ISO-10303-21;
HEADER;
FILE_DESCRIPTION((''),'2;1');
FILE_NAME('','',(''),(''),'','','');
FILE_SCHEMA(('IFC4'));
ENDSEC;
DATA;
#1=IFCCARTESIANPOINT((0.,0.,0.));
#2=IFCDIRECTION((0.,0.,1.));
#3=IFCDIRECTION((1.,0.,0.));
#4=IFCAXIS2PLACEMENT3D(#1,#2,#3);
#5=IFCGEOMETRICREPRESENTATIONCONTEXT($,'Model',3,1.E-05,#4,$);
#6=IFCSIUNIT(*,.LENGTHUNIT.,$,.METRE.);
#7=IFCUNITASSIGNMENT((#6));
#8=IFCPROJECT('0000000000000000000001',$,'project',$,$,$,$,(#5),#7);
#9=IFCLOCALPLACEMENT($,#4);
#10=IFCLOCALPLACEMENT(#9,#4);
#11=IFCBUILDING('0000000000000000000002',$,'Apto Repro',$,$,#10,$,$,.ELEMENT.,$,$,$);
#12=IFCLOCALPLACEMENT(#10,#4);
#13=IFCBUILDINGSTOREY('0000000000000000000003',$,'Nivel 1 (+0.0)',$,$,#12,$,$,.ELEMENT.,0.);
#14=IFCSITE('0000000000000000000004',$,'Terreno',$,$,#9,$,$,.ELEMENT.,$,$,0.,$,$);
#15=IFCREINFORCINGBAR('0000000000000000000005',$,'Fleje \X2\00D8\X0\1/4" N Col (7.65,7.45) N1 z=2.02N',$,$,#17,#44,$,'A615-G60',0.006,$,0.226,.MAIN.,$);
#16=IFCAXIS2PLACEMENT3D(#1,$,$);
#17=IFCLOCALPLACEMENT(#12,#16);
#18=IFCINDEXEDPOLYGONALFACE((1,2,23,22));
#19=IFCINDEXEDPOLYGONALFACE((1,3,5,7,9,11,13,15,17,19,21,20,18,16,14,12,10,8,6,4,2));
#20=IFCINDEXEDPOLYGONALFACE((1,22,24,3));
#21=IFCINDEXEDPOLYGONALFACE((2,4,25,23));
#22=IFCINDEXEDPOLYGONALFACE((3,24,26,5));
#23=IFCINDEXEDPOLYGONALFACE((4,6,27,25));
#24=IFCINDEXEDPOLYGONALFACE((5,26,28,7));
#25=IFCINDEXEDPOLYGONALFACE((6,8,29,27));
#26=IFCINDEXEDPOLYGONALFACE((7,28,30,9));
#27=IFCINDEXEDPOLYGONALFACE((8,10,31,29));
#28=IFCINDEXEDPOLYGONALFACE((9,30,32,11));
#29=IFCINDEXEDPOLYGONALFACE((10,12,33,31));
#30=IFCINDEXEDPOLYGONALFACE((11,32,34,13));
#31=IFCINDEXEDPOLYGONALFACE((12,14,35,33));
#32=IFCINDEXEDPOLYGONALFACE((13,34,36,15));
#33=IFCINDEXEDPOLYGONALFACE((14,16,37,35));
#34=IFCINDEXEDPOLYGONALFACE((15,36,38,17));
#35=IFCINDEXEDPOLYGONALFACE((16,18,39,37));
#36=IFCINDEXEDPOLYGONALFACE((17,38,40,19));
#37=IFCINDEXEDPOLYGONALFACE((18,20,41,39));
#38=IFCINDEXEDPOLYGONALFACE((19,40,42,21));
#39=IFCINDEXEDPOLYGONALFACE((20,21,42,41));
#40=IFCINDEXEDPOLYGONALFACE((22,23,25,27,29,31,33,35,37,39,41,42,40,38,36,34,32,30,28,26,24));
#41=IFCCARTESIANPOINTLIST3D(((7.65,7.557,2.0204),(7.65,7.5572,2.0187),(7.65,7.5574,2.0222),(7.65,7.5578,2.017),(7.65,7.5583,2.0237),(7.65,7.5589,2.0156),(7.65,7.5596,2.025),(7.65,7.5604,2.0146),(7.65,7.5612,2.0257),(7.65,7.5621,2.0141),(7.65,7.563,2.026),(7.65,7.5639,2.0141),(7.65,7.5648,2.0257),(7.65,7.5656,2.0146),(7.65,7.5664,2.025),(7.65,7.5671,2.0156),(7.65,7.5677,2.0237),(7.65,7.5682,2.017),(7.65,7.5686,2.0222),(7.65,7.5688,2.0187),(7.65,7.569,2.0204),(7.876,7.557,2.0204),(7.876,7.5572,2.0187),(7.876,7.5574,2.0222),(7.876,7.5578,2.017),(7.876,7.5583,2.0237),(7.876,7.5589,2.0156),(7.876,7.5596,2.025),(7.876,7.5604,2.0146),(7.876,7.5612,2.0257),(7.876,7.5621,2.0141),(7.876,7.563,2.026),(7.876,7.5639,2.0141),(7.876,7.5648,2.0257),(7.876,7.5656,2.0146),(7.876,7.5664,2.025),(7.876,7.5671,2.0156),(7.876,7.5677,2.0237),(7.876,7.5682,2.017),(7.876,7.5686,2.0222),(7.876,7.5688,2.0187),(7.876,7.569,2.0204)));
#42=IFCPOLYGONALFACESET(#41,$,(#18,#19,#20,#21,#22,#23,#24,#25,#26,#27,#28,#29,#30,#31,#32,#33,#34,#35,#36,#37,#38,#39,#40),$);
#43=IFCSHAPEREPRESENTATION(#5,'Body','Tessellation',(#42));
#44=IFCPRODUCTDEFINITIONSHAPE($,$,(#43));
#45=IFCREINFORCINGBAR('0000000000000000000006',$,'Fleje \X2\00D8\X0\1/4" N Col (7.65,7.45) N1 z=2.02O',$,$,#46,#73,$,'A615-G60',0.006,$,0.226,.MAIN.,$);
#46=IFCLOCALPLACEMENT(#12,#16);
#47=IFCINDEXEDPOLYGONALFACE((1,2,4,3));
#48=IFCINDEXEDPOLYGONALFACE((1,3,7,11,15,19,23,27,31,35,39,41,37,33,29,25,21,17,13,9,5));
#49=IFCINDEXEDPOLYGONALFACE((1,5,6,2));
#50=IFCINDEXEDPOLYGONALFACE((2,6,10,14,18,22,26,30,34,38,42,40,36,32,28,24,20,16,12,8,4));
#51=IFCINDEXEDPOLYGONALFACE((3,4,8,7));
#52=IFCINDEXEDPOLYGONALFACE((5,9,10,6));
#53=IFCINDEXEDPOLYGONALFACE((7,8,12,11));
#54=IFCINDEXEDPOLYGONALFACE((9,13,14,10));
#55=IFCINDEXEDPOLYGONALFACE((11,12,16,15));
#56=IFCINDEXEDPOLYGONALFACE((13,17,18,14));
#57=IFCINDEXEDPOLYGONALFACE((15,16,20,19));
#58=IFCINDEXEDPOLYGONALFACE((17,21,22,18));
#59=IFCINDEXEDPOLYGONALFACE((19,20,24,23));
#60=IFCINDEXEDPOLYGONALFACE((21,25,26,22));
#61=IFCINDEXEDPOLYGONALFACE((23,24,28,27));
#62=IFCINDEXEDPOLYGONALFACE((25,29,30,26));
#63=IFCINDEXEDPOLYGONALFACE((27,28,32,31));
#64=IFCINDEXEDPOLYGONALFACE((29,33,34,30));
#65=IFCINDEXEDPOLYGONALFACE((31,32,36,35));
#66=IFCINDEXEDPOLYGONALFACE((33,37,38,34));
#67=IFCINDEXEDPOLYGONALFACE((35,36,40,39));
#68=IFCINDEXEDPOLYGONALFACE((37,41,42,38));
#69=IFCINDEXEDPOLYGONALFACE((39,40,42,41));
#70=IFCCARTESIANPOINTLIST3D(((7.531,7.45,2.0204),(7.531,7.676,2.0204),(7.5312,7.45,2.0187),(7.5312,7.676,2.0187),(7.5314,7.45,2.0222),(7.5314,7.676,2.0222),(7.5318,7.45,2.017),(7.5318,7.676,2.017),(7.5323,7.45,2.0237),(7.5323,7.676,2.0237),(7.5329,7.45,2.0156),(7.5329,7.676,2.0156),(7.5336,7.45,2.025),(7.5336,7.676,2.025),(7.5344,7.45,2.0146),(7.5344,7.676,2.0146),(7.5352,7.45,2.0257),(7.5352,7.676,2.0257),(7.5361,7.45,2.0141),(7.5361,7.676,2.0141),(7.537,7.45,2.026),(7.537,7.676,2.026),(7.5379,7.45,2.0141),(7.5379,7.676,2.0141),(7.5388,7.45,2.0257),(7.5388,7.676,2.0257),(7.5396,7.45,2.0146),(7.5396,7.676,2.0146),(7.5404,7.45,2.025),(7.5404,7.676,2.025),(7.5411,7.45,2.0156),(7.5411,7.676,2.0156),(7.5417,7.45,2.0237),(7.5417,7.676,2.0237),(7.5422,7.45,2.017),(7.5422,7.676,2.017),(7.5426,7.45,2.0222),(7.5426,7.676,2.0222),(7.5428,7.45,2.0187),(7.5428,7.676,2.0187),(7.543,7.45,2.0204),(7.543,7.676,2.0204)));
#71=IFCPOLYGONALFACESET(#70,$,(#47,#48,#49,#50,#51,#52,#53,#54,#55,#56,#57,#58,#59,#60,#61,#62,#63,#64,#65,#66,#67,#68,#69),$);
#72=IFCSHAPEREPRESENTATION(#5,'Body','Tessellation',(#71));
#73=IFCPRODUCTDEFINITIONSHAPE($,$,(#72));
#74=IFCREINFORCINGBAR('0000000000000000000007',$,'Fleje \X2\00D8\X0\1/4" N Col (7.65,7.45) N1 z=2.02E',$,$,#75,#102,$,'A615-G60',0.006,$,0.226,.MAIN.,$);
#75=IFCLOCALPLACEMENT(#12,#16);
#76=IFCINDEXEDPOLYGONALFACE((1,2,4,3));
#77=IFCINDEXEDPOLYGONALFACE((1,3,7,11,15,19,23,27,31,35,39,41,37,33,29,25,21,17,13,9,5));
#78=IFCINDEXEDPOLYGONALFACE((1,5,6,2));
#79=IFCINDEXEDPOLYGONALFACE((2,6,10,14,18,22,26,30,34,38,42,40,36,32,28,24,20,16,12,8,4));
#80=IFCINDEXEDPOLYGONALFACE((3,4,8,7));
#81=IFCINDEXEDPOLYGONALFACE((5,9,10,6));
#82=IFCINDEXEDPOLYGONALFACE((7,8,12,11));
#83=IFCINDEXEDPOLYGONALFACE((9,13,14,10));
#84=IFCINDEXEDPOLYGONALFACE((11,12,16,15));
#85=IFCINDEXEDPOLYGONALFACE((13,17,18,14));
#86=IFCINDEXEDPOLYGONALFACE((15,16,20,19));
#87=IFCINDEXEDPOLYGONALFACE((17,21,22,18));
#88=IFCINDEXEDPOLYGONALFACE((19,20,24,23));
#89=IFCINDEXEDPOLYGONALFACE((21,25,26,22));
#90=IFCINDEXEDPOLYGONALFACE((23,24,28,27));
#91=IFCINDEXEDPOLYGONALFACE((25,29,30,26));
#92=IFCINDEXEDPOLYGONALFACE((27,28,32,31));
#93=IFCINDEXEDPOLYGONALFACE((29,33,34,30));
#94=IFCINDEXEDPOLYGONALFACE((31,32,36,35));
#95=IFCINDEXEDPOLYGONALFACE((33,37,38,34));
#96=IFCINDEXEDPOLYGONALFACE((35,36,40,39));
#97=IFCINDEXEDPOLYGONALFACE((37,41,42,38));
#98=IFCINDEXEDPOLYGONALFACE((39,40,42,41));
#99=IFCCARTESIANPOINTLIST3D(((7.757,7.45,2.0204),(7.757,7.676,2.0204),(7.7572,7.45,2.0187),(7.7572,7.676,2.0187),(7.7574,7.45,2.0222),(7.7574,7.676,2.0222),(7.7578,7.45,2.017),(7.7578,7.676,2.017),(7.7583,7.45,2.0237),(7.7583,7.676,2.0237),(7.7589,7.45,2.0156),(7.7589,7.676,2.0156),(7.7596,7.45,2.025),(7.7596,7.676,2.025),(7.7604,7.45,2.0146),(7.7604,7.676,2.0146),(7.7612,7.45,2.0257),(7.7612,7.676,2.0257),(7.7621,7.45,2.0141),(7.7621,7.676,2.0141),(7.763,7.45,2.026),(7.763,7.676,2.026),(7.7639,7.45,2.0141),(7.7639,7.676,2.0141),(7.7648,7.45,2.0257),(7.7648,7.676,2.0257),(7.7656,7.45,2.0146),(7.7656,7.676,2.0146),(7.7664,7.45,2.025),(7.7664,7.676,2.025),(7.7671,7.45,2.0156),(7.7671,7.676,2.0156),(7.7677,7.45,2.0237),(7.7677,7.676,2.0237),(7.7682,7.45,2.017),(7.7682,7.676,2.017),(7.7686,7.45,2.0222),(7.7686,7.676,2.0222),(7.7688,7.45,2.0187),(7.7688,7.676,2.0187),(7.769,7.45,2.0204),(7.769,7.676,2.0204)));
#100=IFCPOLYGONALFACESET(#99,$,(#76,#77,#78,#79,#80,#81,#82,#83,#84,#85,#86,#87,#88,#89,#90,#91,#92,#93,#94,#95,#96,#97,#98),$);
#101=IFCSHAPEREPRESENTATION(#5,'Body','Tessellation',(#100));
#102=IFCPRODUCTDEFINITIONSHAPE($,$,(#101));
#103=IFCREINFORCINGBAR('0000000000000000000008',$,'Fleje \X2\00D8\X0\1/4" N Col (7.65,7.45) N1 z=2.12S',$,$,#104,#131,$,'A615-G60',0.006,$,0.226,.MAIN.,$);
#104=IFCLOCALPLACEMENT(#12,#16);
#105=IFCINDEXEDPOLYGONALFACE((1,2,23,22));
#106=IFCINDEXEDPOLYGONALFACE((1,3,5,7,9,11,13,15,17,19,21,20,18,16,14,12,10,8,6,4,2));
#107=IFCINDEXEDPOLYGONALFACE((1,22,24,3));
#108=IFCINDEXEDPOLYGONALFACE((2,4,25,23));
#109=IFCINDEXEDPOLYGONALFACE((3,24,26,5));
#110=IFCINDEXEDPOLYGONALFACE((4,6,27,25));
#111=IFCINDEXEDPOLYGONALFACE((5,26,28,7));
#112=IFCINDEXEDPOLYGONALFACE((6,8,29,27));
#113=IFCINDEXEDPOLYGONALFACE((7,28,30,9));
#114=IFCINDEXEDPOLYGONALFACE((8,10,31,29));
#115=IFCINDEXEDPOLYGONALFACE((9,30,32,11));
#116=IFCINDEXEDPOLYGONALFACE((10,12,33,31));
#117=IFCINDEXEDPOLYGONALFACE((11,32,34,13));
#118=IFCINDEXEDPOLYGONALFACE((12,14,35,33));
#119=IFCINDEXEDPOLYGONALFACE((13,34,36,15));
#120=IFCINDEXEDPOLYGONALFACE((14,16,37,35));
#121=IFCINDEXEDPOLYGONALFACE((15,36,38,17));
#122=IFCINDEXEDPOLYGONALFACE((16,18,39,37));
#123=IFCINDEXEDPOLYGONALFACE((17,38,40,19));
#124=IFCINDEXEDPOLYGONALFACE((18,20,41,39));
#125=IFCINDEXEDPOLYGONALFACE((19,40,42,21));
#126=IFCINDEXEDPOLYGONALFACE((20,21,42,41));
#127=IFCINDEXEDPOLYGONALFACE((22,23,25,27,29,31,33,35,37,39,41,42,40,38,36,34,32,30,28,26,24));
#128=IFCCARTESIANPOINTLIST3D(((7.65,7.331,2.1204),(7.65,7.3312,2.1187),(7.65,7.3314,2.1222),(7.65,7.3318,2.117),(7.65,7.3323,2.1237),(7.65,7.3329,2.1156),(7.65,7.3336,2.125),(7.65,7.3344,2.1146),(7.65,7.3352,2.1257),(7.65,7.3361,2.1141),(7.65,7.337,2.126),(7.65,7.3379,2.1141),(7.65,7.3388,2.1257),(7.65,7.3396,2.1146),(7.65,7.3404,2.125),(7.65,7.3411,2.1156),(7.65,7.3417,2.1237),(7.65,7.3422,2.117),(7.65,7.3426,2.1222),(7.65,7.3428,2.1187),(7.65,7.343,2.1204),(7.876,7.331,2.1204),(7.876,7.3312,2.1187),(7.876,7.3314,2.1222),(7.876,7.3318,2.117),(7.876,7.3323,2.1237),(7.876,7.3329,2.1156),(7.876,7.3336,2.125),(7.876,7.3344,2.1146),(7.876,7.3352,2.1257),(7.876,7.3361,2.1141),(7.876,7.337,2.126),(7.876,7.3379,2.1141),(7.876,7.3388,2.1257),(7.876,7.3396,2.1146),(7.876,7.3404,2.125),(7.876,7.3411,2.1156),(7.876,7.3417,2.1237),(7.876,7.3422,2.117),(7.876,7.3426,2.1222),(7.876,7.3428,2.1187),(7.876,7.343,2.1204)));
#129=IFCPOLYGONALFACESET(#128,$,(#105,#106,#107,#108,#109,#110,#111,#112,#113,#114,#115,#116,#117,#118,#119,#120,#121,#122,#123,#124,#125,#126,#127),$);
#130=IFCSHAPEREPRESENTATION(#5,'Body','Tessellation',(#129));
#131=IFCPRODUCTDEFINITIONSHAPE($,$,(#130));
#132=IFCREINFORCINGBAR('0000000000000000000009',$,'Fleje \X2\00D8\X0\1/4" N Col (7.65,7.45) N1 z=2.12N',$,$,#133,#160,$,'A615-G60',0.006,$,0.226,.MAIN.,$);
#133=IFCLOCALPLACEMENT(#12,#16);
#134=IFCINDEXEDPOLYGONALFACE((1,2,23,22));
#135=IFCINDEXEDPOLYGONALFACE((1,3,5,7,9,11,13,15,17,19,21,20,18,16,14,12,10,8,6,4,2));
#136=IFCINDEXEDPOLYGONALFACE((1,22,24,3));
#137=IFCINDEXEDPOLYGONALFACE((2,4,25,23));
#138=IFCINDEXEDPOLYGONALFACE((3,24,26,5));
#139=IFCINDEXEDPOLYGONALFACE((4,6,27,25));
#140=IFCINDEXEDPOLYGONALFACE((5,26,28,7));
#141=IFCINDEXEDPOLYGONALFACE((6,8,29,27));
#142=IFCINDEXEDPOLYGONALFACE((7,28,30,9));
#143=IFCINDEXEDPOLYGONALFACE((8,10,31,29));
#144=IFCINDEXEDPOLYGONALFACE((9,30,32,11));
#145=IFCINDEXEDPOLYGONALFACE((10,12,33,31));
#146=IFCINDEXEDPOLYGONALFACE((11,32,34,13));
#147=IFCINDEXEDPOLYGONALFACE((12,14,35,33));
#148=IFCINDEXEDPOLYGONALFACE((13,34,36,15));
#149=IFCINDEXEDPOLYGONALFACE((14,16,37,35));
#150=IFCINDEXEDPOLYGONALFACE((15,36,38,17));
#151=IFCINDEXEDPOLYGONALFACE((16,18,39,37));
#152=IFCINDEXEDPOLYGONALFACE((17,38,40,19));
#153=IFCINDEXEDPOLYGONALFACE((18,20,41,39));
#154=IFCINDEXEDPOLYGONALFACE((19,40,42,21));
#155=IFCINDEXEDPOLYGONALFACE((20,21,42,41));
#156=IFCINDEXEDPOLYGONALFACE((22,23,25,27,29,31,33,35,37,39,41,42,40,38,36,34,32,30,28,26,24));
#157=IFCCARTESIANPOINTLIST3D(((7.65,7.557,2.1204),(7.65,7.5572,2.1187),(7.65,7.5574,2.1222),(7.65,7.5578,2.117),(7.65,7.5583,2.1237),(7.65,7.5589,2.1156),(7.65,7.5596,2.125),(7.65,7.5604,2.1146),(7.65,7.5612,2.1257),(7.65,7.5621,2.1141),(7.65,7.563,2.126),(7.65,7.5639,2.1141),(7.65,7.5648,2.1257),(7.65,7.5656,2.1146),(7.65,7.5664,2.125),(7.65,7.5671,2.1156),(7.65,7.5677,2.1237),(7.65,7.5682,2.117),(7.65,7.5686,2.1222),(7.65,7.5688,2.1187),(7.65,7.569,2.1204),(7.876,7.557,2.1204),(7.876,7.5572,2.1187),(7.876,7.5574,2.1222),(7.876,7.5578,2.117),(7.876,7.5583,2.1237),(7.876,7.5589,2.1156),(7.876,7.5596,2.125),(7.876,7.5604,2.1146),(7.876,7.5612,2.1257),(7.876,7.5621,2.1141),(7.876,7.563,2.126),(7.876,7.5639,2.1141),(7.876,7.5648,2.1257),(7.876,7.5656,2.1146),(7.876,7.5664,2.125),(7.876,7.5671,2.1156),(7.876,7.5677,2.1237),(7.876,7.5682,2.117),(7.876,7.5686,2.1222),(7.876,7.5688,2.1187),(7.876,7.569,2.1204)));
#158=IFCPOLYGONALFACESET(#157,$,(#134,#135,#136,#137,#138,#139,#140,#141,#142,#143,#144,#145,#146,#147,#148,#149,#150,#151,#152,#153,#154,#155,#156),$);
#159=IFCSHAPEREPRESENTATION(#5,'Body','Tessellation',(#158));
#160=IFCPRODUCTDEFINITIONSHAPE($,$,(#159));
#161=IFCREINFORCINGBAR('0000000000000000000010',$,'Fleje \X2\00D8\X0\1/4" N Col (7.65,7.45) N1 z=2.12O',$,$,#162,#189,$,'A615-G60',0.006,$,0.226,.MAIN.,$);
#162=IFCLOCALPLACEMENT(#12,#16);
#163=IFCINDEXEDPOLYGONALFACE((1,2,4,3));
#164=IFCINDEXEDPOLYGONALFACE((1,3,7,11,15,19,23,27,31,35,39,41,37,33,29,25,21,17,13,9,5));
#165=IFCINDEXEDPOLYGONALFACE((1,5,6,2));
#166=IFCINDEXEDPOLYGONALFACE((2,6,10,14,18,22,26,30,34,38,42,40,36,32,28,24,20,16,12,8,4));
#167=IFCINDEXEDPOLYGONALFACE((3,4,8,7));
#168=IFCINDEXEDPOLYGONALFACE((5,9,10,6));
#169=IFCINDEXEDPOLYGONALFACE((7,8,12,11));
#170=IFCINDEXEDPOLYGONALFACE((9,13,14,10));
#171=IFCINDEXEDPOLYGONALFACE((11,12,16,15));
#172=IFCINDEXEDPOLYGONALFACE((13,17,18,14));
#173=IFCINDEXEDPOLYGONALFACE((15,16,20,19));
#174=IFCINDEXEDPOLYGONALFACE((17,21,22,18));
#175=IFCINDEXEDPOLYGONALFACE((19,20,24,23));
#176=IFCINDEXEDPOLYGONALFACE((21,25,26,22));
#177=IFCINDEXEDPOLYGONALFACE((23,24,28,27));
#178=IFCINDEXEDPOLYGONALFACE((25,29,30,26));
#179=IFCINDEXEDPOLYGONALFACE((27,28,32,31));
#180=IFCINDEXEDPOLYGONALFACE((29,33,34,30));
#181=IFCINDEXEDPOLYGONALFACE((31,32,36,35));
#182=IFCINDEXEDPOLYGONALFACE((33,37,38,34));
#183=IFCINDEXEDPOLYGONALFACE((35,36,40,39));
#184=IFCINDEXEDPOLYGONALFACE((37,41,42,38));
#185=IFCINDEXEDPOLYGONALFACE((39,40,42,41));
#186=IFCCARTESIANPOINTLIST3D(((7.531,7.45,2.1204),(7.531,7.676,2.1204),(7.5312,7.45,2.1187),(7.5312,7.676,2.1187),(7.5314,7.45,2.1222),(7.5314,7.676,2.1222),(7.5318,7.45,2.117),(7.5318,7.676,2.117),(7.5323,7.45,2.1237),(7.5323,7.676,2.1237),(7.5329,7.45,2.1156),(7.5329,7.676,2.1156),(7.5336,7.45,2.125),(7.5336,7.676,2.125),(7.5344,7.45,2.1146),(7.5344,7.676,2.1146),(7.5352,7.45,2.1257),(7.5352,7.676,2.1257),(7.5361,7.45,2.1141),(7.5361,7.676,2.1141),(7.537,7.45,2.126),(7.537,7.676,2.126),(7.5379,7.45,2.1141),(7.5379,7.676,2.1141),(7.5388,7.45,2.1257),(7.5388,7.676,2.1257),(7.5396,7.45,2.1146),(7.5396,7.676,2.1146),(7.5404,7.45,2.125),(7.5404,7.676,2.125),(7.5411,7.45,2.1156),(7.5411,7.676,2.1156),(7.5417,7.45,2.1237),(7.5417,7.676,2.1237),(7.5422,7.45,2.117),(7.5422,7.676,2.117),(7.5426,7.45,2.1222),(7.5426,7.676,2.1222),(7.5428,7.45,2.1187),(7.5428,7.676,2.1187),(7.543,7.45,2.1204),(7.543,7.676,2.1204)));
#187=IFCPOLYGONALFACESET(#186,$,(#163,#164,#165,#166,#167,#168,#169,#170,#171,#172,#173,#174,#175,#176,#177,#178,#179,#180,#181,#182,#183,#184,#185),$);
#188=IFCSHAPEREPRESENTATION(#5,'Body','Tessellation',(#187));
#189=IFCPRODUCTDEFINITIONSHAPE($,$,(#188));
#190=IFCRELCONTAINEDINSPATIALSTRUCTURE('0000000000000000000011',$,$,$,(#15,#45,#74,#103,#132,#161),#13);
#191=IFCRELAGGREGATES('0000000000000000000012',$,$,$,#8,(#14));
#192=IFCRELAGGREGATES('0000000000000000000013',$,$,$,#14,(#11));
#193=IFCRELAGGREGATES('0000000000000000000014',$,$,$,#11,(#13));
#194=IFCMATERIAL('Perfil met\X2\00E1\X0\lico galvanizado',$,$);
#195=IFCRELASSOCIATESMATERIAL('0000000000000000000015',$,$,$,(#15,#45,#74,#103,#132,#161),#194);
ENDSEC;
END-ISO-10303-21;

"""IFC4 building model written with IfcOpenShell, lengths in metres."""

from ifc_helpers import new_model, si_unit, frame, origin_with_axes, origin_2d_with_axis, place, context, project, spatial, circle, extrude, material, element, save


model = new_model("IFC4")

# Units and contexts
model_context = context("Model", 3, precision=1e-05, world=origin_with_axes())
ifc_project = project(units=[si_unit("LENGTHUNIT", "METRE")], contexts=[model_context])

# Site, building, storey
site_placement = place(None, origin_with_axes())
site = spatial("IfcSite", under=ifc_project, at=site_placement, Name="Terreno", CompositionType="ELEMENT", RefElevation=0.0)
building_placement = place(site_placement, origin_with_axes())
building = spatial("IfcBuilding", under=site, at=building_placement, Name="Apto Repro", CompositionType="ELEMENT")
storey_placement = place(building_placement, origin_with_axes())
storey = spatial("IfcBuildingStorey", under=building, at=storey_placement, Name="Nivel 1 (+0.0)", CompositionType="ELEMENT", Elevation=0.0)

# Reinforcing bars
ifc_material = material(Name="Perfil metálico galvanizado")
reinforcing_bar_1_placement = place(storey_placement, origin_with_axes())
element("IfcReinforcingBar", 1, at=reinforcing_bar_1_placement, inside=storey, material=ifc_material, Name="Fleje Ø1/4\" N Col (7.65,7.45) N1 z=2.02N", SteelGrade="A615-G60", BarLength=0.226, NominalDiameter=0.006, PredefinedType="MAIN", context=model_context, shape_type="SweptSolid", body=[
    extrude(circle(Radius=0.006, at=origin_2d_with_axis()), frame((7.65, 7.563, 2.02), z_axis=(1.0, 0.0, 0.0), x_axis=(0.0, 0.0, 1.0)), (0.0, 0.0, 1.0), 0.226),
])
reinforcing_bar_2_placement = place(storey_placement, origin_with_axes())
element("IfcReinforcingBar", 2, at=reinforcing_bar_2_placement, inside=storey, material=ifc_material, Name="Fleje Ø1/4\" N Col (7.65,7.45) N1 z=2.02O", SteelGrade="A615-G60", BarLength=0.226, NominalDiameter=0.006, PredefinedType="MAIN", context=model_context, shape_type="SweptSolid", body=[
    extrude(circle(Radius=0.006, at=origin_2d_with_axis()), frame((7.537, 7.45, 2.02), z_axis=(0.0, 1.0, 0.0), x_axis=(0.0, 0.0, 1.0)), (0.0, 0.0, 1.0), 0.226),
])
reinforcing_bar_3_placement = place(storey_placement, origin_with_axes())
element("IfcReinforcingBar", 3, at=reinforcing_bar_3_placement, inside=storey, material=ifc_material, Name="Fleje Ø1/4\" N Col (7.65,7.45) N1 z=2.02E", SteelGrade="A615-G60", BarLength=0.226, NominalDiameter=0.006, PredefinedType="MAIN", context=model_context, shape_type="SweptSolid", body=[
    extrude(circle(Radius=0.006, at=origin_2d_with_axis()), frame((7.763, 7.45, 2.02), z_axis=(0.0, 1.0, 0.0), x_axis=(0.0, 0.0, 1.0)), (0.0, 0.0, 1.0), 0.226),
])
reinforcing_bar_4_placement = place(storey_placement, origin_with_axes())
element("IfcReinforcingBar", 4, at=reinforcing_bar_4_placement, inside=storey, material=ifc_material, Name="Fleje Ø1/4\" N Col (7.65,7.45) N1 z=2.12S", SteelGrade="A615-G60", BarLength=0.226, NominalDiameter=0.006, PredefinedType="MAIN", context=model_context, shape_type="SweptSolid", body=[
    extrude(circle(Radius=0.006, at=origin_2d_with_axis()), frame((7.65, 7.337, 2.12), z_axis=(1.0, 0.0, 0.0), x_axis=(0.0, 0.0, 1.0)), (0.0, 0.0, 1.0), 0.226),
])
reinforcing_bar_5_placement = place(storey_placement, origin_with_axes())
element("IfcReinforcingBar", 5, at=reinforcing_bar_5_placement, inside=storey, material=ifc_material, Name="Fleje Ø1/4\" N Col (7.65,7.45) N1 z=2.12N", SteelGrade="A615-G60", BarLength=0.226, NominalDiameter=0.006, PredefinedType="MAIN", context=model_context, shape_type="SweptSolid", body=[
    extrude(circle(Radius=0.006, at=origin_2d_with_axis()), frame((7.65, 7.563, 2.12), z_axis=(1.0, 0.0, 0.0), x_axis=(0.0, 0.0, 1.0)), (0.0, 0.0, 1.0), 0.226),
])
reinforcing_bar_6_placement = place(storey_placement, origin_with_axes())
element("IfcReinforcingBar", 6, at=reinforcing_bar_6_placement, inside=storey, material=ifc_material, Name="Fleje Ø1/4\" N Col (7.65,7.45) N1 z=2.12O", SteelGrade="A615-G60", BarLength=0.226, NominalDiameter=0.006, PredefinedType="MAIN", context=model_context, shape_type="SweptSolid", body=[
    extrude(circle(Radius=0.006, at=origin_2d_with_axis()), frame((7.537, 7.45, 2.12), z_axis=(0.0, 1.0, 0.0), x_axis=(0.0, 0.0, 1.0)), (0.0, 0.0, 1.0), 0.226),
])

save(model, "model.ifc")
